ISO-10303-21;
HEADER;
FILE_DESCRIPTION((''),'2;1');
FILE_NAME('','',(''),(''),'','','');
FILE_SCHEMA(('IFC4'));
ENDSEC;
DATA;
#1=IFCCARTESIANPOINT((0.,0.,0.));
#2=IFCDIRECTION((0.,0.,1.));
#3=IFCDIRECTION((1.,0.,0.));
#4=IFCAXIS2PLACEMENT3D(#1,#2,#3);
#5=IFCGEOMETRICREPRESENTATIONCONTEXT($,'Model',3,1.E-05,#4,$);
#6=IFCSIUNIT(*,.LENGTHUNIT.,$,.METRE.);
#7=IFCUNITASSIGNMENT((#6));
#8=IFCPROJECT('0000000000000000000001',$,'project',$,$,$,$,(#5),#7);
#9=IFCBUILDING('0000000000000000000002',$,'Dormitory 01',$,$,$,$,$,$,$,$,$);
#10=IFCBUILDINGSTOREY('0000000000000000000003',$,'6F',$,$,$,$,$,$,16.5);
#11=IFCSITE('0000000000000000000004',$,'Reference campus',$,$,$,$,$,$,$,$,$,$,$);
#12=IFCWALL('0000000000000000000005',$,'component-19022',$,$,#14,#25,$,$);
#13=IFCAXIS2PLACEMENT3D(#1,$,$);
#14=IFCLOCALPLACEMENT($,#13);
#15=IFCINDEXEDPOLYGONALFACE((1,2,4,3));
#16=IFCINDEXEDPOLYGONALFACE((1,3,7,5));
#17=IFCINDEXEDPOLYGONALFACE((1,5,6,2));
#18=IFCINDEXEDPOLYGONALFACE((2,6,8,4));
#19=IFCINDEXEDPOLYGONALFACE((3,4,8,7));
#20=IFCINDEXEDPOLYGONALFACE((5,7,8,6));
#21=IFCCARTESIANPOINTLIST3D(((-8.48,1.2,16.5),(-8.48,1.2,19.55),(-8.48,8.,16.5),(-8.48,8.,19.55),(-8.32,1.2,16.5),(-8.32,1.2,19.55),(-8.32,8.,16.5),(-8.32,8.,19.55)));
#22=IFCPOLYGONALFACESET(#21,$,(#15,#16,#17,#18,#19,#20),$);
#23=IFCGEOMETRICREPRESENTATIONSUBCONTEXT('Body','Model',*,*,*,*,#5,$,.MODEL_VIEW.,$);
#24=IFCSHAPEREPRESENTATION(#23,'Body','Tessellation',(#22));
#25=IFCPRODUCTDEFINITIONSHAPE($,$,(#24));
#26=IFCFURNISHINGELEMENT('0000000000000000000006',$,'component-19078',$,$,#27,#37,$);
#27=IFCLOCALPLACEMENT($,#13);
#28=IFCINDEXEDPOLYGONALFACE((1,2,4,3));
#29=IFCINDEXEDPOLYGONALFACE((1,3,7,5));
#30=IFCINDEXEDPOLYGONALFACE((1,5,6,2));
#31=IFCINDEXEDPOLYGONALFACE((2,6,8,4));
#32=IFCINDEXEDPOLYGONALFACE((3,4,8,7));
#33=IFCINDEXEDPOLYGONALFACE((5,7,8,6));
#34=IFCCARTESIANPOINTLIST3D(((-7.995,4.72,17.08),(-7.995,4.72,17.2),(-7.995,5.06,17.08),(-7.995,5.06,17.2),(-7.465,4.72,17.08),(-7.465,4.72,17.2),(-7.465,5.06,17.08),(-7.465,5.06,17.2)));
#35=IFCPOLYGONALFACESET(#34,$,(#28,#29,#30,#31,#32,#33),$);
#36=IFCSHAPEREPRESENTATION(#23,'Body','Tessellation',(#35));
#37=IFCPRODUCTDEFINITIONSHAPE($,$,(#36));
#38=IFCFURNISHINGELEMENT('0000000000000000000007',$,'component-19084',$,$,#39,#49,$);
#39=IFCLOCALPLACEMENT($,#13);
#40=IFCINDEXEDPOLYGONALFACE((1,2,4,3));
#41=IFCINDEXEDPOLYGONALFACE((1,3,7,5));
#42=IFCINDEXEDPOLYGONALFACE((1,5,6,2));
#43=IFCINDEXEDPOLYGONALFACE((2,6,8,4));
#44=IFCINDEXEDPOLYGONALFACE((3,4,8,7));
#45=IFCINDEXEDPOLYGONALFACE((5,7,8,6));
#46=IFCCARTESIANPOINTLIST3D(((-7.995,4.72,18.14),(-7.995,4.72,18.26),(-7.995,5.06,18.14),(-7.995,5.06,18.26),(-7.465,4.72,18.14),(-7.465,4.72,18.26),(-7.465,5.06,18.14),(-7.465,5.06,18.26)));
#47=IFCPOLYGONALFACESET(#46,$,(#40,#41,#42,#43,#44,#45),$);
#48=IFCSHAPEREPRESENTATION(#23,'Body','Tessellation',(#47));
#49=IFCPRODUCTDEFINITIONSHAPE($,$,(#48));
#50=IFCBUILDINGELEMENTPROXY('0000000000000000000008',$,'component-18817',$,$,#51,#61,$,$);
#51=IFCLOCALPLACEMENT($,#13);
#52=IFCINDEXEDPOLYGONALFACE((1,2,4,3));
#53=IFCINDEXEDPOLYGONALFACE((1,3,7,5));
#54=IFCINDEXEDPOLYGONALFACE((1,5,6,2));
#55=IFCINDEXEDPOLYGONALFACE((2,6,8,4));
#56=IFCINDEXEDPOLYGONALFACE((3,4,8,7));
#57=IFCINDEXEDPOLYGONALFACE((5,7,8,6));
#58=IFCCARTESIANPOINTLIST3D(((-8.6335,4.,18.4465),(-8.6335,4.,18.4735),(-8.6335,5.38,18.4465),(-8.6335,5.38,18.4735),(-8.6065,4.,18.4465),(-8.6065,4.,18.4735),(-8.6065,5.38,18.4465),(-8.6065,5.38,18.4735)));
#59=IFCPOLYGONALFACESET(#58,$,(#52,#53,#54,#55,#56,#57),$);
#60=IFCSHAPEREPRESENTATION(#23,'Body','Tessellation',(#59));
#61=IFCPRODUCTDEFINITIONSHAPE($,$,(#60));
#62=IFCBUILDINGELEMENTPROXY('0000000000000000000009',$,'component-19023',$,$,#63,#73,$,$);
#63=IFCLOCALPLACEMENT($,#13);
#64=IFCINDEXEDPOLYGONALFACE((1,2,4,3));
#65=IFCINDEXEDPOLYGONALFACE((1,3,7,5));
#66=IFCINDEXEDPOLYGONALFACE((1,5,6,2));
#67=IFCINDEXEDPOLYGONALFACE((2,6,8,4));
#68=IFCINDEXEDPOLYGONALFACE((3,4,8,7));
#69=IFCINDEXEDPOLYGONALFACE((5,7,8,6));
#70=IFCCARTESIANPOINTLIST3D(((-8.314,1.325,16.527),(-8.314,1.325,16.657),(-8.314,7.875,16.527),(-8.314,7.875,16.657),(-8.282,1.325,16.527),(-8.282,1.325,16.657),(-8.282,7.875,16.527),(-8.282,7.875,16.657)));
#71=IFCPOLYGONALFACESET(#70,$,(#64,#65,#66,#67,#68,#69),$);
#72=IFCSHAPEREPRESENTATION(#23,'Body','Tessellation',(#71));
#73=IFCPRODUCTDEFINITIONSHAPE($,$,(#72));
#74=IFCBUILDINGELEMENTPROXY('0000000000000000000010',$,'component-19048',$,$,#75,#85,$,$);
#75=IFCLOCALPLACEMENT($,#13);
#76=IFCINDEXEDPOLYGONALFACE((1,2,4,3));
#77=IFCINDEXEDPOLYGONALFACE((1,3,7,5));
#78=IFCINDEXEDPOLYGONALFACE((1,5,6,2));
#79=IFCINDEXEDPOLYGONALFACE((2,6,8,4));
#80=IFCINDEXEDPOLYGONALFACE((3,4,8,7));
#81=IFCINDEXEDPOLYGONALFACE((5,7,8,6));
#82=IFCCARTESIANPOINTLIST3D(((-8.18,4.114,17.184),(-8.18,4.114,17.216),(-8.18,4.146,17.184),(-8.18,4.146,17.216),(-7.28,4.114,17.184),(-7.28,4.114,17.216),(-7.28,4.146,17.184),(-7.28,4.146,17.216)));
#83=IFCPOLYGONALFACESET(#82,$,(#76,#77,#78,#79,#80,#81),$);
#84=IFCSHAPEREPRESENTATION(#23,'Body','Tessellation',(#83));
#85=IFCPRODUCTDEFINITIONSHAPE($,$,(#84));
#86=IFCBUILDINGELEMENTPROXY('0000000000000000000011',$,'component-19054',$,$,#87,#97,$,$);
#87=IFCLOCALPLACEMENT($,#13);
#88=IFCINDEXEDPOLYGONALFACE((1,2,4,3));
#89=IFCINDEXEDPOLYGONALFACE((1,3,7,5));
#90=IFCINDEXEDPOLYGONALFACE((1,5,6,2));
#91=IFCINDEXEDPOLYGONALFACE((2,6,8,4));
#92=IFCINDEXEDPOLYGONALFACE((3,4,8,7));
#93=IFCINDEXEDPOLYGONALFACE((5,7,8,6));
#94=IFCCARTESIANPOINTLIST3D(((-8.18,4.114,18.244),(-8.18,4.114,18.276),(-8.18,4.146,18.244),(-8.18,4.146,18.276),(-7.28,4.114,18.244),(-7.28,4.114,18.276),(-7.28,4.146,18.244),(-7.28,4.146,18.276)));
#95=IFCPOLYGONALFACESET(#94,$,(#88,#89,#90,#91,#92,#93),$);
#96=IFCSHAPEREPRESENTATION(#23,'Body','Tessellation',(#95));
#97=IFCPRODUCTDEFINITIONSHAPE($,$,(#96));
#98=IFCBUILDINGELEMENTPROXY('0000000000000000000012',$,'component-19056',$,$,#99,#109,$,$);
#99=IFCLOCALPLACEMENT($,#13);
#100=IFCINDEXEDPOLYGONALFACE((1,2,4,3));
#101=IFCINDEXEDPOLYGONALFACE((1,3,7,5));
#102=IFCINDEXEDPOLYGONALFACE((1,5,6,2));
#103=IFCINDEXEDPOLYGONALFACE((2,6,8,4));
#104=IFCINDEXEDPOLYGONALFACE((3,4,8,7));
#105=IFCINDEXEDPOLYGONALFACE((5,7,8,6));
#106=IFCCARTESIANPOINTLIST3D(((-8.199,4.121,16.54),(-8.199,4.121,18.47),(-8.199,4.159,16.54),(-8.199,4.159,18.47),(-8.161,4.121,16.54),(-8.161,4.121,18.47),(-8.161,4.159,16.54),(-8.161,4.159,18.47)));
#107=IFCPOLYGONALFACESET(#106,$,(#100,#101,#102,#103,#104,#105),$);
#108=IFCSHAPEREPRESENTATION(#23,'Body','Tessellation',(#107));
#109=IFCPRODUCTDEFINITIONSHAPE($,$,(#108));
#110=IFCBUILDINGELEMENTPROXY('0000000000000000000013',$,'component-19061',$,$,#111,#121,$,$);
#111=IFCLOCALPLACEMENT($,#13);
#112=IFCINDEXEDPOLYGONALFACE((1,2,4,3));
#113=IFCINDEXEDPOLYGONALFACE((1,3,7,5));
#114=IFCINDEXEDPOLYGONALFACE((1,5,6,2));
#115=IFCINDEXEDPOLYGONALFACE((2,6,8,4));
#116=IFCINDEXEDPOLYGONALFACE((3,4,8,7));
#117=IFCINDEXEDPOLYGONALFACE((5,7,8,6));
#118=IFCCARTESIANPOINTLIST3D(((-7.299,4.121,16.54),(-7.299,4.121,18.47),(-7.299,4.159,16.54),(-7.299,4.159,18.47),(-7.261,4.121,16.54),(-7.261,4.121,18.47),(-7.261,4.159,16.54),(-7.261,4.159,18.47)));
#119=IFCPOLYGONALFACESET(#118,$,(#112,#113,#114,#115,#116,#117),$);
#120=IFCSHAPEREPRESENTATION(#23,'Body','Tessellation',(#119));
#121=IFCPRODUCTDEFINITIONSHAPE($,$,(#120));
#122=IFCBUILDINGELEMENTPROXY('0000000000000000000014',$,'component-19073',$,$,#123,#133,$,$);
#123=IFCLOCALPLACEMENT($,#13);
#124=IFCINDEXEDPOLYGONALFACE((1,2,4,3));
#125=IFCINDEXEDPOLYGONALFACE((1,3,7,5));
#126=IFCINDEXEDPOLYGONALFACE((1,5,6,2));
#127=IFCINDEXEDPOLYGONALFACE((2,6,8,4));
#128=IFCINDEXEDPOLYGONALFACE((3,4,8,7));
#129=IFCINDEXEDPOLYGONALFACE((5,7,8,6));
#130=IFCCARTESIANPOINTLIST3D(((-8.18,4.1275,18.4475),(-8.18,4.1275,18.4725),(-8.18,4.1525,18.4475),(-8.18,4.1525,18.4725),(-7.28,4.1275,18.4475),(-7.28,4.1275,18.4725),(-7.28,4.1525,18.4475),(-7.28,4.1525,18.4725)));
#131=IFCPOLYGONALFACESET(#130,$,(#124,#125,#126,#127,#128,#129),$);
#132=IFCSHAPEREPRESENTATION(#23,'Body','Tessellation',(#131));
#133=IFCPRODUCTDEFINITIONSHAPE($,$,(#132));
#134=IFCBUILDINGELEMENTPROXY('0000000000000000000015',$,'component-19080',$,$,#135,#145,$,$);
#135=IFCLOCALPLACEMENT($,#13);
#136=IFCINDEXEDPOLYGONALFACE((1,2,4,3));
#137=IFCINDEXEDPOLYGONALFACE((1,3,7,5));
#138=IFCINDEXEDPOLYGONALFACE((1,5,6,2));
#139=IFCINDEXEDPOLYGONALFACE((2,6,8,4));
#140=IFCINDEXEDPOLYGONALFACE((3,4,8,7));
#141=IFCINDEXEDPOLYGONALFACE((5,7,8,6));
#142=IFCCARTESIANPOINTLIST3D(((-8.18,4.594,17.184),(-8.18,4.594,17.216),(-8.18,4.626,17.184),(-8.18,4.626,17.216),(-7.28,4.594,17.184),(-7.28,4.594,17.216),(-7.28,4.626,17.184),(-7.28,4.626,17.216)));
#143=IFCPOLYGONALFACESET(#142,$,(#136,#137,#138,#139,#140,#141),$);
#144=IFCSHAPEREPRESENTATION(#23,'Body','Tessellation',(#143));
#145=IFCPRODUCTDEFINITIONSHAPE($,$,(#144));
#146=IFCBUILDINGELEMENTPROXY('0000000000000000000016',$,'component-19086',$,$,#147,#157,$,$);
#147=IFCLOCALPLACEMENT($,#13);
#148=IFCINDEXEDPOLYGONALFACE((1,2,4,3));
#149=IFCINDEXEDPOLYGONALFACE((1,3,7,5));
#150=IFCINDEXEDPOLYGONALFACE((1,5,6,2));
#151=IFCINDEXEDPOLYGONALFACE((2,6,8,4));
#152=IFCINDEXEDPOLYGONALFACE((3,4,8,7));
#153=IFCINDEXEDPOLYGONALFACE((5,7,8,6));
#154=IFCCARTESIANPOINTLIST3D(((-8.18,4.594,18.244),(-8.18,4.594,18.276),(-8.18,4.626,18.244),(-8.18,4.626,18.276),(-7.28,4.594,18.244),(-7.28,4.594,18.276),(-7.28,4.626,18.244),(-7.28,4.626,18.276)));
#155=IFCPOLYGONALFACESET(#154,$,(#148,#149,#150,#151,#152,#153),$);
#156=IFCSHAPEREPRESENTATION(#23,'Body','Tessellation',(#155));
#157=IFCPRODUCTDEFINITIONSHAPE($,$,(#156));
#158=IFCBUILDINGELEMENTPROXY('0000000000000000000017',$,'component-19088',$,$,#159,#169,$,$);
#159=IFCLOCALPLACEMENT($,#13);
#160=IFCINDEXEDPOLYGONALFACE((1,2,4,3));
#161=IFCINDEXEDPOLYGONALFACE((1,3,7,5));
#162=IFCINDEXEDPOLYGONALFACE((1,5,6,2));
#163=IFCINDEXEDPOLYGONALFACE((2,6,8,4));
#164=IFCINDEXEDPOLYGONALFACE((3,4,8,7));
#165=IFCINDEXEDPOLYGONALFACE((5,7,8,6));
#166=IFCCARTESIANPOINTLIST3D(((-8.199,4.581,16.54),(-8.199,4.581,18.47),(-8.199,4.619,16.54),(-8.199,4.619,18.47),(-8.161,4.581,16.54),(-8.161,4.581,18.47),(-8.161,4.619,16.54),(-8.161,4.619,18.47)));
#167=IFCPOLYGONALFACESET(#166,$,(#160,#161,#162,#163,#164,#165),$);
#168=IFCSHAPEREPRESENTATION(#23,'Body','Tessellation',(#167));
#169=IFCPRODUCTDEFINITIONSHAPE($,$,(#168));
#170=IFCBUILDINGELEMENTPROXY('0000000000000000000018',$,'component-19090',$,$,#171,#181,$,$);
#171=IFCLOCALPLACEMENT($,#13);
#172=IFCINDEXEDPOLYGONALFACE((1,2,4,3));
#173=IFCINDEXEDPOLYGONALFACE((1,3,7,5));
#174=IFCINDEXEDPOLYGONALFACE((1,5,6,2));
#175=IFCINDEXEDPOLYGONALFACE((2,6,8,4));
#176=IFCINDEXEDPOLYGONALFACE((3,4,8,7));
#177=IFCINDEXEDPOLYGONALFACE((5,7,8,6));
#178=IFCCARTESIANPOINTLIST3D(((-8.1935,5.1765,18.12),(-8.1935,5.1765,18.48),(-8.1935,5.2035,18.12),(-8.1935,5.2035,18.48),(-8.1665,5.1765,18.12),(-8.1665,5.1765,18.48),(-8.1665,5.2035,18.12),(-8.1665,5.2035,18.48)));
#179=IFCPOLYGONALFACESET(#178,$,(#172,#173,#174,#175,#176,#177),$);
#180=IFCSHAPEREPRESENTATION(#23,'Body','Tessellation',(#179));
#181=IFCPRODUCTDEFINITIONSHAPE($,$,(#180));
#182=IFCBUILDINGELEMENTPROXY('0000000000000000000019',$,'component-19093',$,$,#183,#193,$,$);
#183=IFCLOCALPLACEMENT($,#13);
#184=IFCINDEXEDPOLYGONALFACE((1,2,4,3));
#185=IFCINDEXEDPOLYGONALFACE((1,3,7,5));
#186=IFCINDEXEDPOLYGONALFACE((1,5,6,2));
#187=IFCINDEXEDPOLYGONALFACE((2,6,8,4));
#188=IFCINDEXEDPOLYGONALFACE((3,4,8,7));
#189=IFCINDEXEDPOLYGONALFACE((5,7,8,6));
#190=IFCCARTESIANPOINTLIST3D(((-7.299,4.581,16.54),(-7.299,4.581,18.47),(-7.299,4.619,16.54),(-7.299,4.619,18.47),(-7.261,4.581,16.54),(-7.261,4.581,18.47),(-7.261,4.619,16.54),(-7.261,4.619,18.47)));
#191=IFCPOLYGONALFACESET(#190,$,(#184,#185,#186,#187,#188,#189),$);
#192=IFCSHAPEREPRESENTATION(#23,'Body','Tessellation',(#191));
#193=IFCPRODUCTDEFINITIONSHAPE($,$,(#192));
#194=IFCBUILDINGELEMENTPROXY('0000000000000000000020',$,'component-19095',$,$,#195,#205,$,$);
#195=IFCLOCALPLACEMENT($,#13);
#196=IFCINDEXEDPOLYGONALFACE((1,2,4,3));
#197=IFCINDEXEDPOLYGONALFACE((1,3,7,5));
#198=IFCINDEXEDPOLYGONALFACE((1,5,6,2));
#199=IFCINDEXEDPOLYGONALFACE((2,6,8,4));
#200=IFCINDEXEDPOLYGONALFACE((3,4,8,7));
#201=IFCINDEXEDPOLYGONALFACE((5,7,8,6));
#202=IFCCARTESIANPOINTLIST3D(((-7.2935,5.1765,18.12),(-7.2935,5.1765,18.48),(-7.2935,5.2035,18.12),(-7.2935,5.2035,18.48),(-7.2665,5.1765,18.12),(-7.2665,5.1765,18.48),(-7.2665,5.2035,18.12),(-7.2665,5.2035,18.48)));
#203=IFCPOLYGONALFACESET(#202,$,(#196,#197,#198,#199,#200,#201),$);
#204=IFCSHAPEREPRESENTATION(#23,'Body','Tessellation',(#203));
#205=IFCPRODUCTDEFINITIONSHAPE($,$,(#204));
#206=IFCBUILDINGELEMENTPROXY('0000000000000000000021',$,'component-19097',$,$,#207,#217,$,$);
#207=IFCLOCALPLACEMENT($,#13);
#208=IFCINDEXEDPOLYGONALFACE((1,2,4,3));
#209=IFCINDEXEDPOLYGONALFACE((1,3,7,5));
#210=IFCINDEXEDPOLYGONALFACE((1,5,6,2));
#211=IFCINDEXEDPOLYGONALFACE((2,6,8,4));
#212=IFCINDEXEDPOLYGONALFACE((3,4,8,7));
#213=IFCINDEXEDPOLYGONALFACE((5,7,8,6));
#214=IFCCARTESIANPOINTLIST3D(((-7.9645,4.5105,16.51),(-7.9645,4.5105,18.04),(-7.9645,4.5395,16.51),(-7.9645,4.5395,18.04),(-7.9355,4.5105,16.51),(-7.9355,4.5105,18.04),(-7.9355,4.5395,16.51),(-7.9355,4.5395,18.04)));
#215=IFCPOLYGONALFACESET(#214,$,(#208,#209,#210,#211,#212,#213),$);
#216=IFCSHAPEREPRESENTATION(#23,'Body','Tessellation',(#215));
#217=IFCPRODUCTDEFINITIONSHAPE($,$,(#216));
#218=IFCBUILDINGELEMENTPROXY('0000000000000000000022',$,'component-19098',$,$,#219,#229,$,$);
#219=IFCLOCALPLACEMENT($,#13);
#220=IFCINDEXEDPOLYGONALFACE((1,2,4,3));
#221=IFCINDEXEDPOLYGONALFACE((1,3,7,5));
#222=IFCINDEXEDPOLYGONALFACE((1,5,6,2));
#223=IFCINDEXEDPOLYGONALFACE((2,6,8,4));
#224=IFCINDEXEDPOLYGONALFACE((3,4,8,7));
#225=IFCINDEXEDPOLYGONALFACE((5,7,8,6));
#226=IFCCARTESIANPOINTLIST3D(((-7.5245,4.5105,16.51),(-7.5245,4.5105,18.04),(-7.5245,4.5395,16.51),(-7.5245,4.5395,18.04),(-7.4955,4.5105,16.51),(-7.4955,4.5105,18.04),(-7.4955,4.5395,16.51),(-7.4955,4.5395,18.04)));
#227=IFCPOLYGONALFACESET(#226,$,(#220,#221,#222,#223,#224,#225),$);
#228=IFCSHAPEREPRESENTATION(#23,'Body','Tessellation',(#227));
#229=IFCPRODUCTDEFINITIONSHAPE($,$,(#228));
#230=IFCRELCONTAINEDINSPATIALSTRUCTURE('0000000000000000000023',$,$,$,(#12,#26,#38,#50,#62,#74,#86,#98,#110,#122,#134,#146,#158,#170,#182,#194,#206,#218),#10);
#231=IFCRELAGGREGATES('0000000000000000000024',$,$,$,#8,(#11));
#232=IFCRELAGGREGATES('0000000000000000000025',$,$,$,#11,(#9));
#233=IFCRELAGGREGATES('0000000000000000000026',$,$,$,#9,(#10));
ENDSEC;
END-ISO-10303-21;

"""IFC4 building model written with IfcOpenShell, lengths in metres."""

from ifc_helpers import new_model, si_unit, frame, origin, origin_with_axes, origin_2d, place, context, subcontext, project, spatial, rectangle, extrude, element, save


model = new_model("IFC4")

# Units and contexts
model_context = context("Model", 3, precision=1e-05, world=origin_with_axes())
body_context = subcontext(model_context, "Body", "Model", "MODEL_VIEW")
ifc_project = project(units=[si_unit("LENGTHUNIT", "METRE")], contexts=[model_context])

# Site, building, storey
site = spatial("IfcSite", under=ifc_project, Name="Reference campus")
building = spatial("IfcBuilding", under=site, Name="Dormitory 01")
storey = spatial("IfcBuildingStorey", under=building, Name="6F", Elevation=16.5)

# Wall
wall_placement = place(None, frame((-8.4, 4.6, 16.5), z_axis=(0.0, 0.0, 1.0), x_axis=(1.0, 0.0, 0.0)))
element("IfcWall", 1, at=wall_placement, inside=storey, Name="component-19022", context=body_context, shape_type="SweptSolid", body=[
    extrude(rectangle(XDim=0.16, YDim=6.8, at=origin_2d()), origin(), (0.0, 0.0, 1.0), 3.05),
])

# Furnishing elements
for number, where, z_axis, x_axis, name in (
    (2, (-7.73, 4.89, 17.08), (0.0, 0.0, 1.0), (1.0, 0.0, 0.0), "component-19078"),
    (3, (-7.73, 4.89, 18.14), (0.0, 0.0, 1.0), (1.0, 0.0, 0.0), "component-19084"),
):
    element("IfcFurnishingElement", number, at=place(None, frame(where, z_axis=z_axis, x_axis=x_axis)), inside=storey, Name=name, context=body_context, shape_type="SweptSolid", body=[
        extrude(rectangle(XDim=0.53, YDim=0.34, at=origin_2d()), origin(), (0.0, 0.0, 1.0), 0.12),
    ])

# Building element proxies
proxy_1_placement = place(None, frame((-8.62, 4.69, 18.4465), z_axis=(0.0, 0.0, 1.0), x_axis=(1.0, 0.0, 0.0)))
element("IfcBuildingElementProxy", 4, at=proxy_1_placement, inside=storey, Name="component-18817", context=body_context, shape_type="SweptSolid", body=[
    extrude(rectangle(XDim=0.027, YDim=1.38, at=origin_2d()), origin(), (0.0, 0.0, 1.0), 0.027),
])
proxy_2_placement = place(None, frame((-8.298, 4.6, 16.527), z_axis=(0.0, 0.0, 1.0), x_axis=(1.0, 0.0, 0.0)))
element("IfcBuildingElementProxy", 5, at=proxy_2_placement, inside=storey, Name="component-19023", context=body_context, shape_type="SweptSolid", body=[
    extrude(rectangle(XDim=0.032, YDim=6.55, at=origin_2d()), origin(), (0.0, 0.0, 1.0), 0.13),
])
for number, where, z_axis, x_axis, name in (
    (6, (-7.73, 4.13, 17.184), (0.0, 0.0, 1.0), (1.0, 0.0, 0.0), "component-19048"),
    (7, (-7.73, 4.13, 18.244), (0.0, 0.0, 1.0), (1.0, 0.0, 0.0), "component-19054"),
):
    element("IfcBuildingElementProxy", number, at=place(None, frame(where, z_axis=z_axis, x_axis=x_axis)), inside=storey, Name=name, context=body_context, shape_type="SweptSolid", body=[
        extrude(rectangle(XDim=0.9, YDim=0.032, at=origin_2d()), origin(), (0.0, 0.0, 1.0), 0.032),
    ])
for number, where, z_axis, x_axis, name in (
    (8, (-8.18, 4.14, 16.54), (0.0, 0.0, 1.0), (1.0, 0.0, 0.0), "component-19056"),
    (9, (-7.28, 4.14, 16.54), (0.0, 0.0, 1.0), (1.0, 0.0, 0.0), "component-19061"),
):
    element("IfcBuildingElementProxy", number, at=place(None, frame(where, z_axis=z_axis, x_axis=x_axis)), inside=storey, Name=name, context=body_context, shape_type="SweptSolid", body=[
        extrude(rectangle(XDim=0.038, YDim=0.038, at=origin_2d()), origin(), (0.0, 0.0, 1.0), 1.93),
    ])
proxy_3_placement = place(None, frame((-7.73, 4.14, 18.4475), z_axis=(0.0, 0.0, 1.0), x_axis=(1.0, 0.0, 0.0)))
element("IfcBuildingElementProxy", 10, at=proxy_3_placement, inside=storey, Name="component-19073", context=body_context, shape_type="SweptSolid", body=[
    extrude(rectangle(XDim=0.9, YDim=0.025, at=origin_2d()), origin(), (0.0, 0.0, 1.0), 0.025),
])
for number, where, z_axis, x_axis, name in (
    (11, (-7.73, 4.61, 17.184), (0.0, 0.0, 1.0), (1.0, 0.0, 0.0), "component-19080"),
    (12, (-7.73, 4.61, 18.244), (0.0, 0.0, 1.0), (1.0, 0.0, 0.0), "component-19086"),
):
    element("IfcBuildingElementProxy", number, at=place(None, frame(where, z_axis=z_axis, x_axis=x_axis)), inside=storey, Name=name, context=body_context, shape_type="SweptSolid", body=[
        extrude(rectangle(XDim=0.9, YDim=0.032, at=origin_2d()), origin(), (0.0, 0.0, 1.0), 0.032),
    ])
proxy_4_placement = place(None, frame((-8.18, 4.6, 16.54), z_axis=(0.0, 0.0, 1.0), x_axis=(1.0, 0.0, 0.0)))
element("IfcBuildingElementProxy", 13, at=proxy_4_placement, inside=storey, Name="component-19088", context=body_context, shape_type="SweptSolid", body=[
    extrude(rectangle(XDim=0.038, YDim=0.038, at=origin_2d()), origin(), (0.0, 0.0, 1.0), 1.93),
])
proxy_5_placement = place(None, frame((-8.18, 5.19, 18.12), z_axis=(0.0, 0.0, 1.0), x_axis=(1.0, 0.0, 0.0)))
element("IfcBuildingElementProxy", 14, at=proxy_5_placement, inside=storey, Name="component-19090", context=body_context, shape_type="SweptSolid", body=[
    extrude(rectangle(XDim=0.027, YDim=0.027, at=origin_2d()), origin(), (0.0, 0.0, 1.0), 0.36),
])
proxy_6_placement = place(None, frame((-7.28, 4.6, 16.54), z_axis=(0.0, 0.0, 1.0), x_axis=(1.0, 0.0, 0.0)))
element("IfcBuildingElementProxy", 15, at=proxy_6_placement, inside=storey, Name="component-19093", context=body_context, shape_type="SweptSolid", body=[
    extrude(rectangle(XDim=0.038, YDim=0.038, at=origin_2d()), origin(), (0.0, 0.0, 1.0), 1.93),
])
proxy_7_placement = place(None, frame((-7.28, 5.19, 18.12), z_axis=(0.0, 0.0, 1.0), x_axis=(1.0, 0.0, 0.0)))
element("IfcBuildingElementProxy", 16, at=proxy_7_placement, inside=storey, Name="component-19095", context=body_context, shape_type="SweptSolid", body=[
    extrude(rectangle(XDim=0.027, YDim=0.027, at=origin_2d()), origin(), (0.0, 0.0, 1.0), 0.36),
])
for number, where, z_axis, x_axis, name in (
    (17, (-7.95, 4.525, 16.51), (0.0, 0.0, 1.0), (1.0, 0.0, 0.0), "component-19097"),
    (18, (-7.51, 4.525, 16.51), (0.0, 0.0, 1.0), (1.0, 0.0, 0.0), "component-19098"),
):
    element("IfcBuildingElementProxy", number, at=place(None, frame(where, z_axis=z_axis, x_axis=x_axis)), inside=storey, Name=name, context=body_context, shape_type="SweptSolid", body=[
        extrude(rectangle(XDim=0.029, YDim=0.029, at=origin_2d()), origin(), (0.0, 0.0, 1.0), 1.53),
    ])

save(model, "model.ifc")
